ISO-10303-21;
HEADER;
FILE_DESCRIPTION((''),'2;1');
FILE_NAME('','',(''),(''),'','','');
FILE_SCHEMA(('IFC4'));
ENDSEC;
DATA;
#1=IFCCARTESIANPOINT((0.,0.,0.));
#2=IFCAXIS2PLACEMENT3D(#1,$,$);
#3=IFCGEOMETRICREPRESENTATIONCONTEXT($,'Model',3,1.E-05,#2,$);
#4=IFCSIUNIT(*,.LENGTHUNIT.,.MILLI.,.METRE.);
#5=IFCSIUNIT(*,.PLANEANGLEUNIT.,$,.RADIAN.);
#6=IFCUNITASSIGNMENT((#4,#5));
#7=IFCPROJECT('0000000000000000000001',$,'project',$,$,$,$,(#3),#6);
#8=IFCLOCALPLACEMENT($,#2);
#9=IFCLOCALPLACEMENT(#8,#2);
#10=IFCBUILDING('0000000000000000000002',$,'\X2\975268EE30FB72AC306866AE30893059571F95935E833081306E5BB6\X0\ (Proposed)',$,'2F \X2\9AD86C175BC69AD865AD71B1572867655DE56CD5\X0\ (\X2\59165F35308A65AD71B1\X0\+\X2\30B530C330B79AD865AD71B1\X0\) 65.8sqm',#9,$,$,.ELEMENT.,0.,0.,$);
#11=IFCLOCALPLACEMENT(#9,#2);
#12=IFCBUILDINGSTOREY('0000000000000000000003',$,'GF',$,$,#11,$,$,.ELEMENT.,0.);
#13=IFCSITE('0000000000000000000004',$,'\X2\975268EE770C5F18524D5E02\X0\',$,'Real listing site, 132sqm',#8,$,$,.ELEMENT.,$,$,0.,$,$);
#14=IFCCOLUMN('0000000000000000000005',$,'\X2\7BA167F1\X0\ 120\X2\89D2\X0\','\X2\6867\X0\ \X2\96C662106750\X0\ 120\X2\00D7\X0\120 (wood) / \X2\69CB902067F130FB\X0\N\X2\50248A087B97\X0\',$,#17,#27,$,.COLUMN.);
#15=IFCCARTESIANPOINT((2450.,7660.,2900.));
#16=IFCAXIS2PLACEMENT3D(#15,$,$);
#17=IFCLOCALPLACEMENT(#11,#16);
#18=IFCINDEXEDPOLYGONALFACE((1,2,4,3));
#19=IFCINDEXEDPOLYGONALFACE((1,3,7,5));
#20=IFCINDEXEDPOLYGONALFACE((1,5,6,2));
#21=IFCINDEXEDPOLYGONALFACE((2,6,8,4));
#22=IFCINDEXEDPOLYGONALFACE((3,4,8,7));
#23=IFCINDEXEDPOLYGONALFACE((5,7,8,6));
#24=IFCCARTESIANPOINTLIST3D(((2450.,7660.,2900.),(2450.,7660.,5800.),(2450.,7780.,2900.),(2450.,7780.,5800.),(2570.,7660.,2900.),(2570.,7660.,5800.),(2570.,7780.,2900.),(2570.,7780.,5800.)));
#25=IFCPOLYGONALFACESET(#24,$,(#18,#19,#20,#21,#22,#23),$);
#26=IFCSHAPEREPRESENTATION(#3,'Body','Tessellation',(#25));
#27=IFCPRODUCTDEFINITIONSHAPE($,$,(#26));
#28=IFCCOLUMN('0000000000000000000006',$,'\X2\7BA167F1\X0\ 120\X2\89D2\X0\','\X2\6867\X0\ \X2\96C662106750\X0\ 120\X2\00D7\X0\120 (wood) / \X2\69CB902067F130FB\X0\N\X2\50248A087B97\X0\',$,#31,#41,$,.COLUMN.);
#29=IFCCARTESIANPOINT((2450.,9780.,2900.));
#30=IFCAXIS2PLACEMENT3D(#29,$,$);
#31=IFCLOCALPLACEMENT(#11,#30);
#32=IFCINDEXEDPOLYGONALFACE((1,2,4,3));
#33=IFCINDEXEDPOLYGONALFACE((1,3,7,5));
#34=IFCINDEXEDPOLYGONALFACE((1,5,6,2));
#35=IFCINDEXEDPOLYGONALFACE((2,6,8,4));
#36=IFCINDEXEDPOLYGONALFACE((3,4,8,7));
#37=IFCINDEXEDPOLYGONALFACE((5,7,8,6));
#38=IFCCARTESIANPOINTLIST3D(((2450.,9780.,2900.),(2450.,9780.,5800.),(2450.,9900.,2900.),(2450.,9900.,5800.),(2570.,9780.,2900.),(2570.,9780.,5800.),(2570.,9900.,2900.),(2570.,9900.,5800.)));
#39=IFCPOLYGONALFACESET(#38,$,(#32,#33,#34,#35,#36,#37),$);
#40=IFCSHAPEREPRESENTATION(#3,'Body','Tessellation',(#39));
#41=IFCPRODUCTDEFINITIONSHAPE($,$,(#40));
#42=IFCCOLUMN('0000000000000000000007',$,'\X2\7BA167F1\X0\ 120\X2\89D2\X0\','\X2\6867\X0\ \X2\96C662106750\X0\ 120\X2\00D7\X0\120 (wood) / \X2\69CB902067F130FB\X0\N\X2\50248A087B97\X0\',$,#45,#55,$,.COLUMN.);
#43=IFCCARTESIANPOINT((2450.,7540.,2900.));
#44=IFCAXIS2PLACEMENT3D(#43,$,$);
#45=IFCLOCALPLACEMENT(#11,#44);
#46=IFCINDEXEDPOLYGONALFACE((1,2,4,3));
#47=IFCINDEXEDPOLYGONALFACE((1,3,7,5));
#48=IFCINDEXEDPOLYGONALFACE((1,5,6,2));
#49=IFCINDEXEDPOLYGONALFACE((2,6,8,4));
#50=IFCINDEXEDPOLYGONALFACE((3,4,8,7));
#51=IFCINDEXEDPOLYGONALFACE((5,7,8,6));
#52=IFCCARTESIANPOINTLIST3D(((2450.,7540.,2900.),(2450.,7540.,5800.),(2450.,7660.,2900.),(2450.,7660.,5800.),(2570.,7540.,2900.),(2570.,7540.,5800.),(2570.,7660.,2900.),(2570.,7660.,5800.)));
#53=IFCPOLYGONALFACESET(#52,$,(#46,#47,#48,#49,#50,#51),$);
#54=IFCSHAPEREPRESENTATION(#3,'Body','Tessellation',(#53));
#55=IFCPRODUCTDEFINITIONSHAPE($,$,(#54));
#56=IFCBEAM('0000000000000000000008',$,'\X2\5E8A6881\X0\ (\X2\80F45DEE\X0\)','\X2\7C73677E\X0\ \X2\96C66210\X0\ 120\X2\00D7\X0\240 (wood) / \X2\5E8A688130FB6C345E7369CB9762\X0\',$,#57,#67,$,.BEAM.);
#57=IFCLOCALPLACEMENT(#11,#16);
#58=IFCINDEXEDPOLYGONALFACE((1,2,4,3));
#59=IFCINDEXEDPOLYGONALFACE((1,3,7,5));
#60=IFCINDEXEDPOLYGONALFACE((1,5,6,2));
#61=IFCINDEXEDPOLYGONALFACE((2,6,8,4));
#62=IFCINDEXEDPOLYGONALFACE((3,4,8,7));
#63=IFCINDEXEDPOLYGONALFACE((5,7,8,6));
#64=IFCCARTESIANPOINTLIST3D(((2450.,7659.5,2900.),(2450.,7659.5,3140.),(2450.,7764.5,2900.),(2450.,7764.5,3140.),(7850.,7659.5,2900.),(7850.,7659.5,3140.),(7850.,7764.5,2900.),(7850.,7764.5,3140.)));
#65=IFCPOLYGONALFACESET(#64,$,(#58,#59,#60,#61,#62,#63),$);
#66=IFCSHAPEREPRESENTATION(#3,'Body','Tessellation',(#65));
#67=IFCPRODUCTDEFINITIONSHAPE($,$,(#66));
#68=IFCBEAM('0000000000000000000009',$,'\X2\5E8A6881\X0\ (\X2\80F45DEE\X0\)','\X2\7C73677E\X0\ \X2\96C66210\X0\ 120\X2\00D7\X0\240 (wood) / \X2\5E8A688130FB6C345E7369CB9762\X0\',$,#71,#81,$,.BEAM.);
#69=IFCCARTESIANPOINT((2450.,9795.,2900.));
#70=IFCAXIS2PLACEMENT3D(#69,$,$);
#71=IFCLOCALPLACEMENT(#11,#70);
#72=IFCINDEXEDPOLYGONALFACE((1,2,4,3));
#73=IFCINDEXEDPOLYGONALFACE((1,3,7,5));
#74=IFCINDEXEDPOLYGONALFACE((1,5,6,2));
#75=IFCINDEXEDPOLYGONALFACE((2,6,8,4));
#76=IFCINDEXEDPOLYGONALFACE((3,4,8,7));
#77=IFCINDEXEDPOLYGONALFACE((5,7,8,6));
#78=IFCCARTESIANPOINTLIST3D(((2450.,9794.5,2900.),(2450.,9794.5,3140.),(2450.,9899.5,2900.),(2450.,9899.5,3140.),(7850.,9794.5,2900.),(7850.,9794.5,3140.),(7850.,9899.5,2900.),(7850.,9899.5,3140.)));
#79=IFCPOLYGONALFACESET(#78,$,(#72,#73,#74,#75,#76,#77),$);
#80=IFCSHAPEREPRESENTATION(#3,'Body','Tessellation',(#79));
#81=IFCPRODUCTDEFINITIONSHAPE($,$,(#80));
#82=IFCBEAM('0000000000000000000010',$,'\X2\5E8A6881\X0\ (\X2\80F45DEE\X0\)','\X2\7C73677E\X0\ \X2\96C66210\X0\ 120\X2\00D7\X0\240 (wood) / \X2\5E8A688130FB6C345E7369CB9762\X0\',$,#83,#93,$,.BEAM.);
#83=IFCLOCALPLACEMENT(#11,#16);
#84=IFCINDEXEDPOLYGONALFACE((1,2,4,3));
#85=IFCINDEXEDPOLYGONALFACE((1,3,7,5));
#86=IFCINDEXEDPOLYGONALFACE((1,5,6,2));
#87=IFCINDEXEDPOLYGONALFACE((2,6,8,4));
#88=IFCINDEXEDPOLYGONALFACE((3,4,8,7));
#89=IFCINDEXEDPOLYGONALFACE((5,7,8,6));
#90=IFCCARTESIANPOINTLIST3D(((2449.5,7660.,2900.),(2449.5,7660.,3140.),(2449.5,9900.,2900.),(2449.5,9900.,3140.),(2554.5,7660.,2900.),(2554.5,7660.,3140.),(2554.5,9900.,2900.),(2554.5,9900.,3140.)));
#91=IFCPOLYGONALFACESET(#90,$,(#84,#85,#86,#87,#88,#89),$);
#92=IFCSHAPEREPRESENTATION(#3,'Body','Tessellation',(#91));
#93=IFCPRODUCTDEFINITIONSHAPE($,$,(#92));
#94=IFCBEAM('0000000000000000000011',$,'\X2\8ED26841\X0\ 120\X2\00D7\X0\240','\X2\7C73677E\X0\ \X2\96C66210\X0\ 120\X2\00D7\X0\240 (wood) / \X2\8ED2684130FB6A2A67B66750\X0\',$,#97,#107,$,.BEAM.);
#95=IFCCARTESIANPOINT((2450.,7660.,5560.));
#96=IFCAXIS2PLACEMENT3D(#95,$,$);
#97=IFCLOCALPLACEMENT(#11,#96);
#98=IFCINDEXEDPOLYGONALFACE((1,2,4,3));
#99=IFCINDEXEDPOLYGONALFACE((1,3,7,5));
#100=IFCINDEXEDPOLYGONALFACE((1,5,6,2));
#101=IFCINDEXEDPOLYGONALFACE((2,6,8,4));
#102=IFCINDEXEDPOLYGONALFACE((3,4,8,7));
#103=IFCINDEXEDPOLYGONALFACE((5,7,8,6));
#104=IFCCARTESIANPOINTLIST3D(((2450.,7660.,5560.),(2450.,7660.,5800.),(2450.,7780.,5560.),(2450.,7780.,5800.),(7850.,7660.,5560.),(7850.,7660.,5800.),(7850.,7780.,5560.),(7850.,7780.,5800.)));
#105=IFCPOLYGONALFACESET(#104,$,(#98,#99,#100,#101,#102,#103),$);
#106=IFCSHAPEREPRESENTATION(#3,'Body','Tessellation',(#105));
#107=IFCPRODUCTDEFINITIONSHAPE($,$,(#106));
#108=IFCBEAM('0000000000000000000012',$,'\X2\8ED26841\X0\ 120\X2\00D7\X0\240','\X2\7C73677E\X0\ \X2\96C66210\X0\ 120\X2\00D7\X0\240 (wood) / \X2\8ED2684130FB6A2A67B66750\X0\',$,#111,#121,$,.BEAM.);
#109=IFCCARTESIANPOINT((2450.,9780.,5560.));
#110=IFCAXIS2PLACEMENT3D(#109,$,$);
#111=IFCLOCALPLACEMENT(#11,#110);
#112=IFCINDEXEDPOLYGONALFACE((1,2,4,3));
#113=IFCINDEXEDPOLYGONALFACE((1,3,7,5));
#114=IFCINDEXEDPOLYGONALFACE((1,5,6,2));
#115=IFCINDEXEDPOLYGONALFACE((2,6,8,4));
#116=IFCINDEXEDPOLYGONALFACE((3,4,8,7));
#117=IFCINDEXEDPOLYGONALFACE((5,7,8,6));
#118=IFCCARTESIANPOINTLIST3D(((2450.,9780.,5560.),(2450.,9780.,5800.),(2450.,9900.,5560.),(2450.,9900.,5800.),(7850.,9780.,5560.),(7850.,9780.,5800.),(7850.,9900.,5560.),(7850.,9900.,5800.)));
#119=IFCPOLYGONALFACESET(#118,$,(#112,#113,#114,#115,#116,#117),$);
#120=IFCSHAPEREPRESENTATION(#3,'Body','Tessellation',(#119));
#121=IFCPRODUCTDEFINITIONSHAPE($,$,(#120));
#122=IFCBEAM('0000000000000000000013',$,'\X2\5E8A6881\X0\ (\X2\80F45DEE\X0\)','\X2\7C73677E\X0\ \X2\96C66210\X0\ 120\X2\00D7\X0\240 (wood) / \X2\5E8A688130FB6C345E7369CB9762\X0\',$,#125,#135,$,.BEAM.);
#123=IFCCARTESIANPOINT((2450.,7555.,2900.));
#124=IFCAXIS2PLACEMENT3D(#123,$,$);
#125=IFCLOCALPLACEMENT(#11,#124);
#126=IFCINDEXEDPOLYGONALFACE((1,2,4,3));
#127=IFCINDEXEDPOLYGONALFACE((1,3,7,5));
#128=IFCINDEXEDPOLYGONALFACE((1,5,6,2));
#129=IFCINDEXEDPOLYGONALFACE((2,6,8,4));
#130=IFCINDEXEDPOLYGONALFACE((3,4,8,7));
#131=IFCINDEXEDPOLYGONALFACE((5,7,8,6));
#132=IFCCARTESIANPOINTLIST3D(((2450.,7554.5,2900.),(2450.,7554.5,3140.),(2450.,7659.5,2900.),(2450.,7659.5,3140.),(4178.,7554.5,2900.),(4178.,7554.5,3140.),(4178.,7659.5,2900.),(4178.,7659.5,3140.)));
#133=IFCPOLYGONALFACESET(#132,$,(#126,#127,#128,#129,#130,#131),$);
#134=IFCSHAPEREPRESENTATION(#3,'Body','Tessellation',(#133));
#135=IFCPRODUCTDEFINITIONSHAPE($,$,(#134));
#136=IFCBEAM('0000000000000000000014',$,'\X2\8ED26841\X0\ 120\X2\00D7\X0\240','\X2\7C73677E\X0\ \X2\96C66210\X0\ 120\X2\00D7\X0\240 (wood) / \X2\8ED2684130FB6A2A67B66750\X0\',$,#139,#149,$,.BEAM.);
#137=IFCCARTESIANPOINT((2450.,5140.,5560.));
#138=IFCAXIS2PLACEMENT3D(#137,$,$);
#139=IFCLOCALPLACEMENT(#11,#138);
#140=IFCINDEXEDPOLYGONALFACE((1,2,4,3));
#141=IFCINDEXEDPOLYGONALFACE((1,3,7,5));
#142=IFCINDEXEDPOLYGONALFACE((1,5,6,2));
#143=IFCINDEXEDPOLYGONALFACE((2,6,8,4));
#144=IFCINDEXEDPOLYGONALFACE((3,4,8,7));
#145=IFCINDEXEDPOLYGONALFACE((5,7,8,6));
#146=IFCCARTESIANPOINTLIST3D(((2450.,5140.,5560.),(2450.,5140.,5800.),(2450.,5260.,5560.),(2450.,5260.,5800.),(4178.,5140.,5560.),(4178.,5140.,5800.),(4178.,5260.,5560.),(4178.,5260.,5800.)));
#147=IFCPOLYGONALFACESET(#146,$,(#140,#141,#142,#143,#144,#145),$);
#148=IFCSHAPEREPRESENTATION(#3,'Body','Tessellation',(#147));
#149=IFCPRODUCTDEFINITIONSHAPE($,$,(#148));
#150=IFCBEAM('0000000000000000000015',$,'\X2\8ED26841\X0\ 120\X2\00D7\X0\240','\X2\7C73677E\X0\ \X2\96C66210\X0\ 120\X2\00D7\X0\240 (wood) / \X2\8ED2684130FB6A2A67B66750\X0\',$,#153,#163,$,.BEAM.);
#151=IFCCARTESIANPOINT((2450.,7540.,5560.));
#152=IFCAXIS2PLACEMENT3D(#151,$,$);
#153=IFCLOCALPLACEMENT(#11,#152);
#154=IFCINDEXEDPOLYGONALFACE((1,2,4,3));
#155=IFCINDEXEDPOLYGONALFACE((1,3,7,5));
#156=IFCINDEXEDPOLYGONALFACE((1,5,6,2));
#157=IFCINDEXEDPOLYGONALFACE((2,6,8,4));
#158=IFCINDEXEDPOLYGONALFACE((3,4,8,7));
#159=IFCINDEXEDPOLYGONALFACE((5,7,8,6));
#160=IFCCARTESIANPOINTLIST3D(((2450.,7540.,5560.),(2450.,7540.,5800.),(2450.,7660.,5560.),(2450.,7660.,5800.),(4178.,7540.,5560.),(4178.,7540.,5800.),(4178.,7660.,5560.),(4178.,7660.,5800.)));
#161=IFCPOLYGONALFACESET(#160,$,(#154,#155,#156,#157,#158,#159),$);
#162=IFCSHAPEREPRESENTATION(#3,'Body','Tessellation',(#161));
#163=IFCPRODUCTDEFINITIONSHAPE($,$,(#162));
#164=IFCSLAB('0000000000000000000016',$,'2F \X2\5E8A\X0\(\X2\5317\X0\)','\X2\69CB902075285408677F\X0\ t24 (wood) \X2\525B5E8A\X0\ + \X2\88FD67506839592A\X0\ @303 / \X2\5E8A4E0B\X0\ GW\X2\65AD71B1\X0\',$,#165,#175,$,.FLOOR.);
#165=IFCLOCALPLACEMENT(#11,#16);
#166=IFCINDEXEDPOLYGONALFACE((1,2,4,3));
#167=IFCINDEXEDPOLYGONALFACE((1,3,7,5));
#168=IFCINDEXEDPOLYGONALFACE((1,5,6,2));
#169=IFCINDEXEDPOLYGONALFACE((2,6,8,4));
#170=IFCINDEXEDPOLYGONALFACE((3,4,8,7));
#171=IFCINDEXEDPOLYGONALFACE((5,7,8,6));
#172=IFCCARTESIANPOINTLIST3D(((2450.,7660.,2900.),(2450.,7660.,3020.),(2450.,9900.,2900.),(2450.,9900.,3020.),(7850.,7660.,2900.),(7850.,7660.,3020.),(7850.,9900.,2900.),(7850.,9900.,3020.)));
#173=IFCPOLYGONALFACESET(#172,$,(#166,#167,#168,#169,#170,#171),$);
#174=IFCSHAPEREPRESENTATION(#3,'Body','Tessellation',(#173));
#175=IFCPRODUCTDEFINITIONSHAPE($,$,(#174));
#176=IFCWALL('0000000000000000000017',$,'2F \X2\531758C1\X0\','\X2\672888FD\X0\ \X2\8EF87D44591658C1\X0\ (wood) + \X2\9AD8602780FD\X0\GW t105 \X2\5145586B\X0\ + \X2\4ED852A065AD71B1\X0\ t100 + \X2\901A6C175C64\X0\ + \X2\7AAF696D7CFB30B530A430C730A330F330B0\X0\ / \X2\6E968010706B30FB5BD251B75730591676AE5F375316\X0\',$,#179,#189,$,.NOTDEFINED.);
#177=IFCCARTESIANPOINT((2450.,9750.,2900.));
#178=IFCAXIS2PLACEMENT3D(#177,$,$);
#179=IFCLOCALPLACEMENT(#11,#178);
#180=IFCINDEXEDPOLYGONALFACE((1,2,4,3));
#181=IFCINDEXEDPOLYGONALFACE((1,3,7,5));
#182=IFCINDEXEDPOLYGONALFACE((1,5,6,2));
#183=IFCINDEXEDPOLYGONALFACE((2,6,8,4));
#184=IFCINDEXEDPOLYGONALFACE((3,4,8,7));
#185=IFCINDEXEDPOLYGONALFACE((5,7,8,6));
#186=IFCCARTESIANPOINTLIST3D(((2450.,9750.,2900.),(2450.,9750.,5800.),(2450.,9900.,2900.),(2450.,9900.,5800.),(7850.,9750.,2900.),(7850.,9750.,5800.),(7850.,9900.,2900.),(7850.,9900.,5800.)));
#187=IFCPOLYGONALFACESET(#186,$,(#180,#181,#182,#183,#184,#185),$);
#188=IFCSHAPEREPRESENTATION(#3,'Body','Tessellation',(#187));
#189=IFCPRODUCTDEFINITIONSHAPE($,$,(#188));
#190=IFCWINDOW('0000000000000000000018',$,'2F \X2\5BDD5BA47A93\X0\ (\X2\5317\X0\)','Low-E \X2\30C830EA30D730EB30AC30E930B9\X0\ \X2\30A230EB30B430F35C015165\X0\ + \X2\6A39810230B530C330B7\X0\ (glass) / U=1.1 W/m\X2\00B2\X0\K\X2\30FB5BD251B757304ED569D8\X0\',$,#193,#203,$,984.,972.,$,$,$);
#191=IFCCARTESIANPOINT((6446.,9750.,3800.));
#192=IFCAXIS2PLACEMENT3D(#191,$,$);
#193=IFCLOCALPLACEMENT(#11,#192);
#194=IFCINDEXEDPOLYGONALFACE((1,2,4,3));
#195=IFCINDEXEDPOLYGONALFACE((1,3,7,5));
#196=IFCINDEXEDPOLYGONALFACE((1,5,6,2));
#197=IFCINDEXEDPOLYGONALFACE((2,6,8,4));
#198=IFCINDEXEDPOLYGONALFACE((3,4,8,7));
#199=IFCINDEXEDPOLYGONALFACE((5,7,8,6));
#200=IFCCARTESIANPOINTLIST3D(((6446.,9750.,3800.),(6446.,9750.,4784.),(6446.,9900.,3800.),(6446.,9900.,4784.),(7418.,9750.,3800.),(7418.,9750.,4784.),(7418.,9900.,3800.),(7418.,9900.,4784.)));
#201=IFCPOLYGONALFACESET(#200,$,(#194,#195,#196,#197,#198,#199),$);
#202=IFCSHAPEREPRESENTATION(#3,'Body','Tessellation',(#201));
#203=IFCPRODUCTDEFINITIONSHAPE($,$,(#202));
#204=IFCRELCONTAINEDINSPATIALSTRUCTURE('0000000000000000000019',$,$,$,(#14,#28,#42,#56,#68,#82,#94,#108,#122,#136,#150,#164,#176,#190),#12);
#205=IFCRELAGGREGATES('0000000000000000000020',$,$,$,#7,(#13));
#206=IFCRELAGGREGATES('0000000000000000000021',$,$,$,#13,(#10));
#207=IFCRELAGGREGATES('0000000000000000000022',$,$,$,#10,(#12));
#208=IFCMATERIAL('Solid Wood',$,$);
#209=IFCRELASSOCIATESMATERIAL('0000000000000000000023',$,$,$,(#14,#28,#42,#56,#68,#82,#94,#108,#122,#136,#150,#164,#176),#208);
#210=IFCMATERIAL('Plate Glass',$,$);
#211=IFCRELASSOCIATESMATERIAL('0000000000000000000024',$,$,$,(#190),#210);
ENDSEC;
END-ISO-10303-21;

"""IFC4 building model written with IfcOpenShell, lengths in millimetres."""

from ifc_helpers import new_model, si_unit, frame, frame_2d, origin, place, context, project, spatial, rectangle, extrude, material, element, fill, save


model = new_model("IFC4")

# Units and contexts
model_context = context("Model", 3, precision=1e-05, world=origin())
ifc_project = project(units=[si_unit("LENGTHUNIT", "METRE", prefix="MILLI"), si_unit("PLANEANGLEUNIT", "RADIAN")], contexts=[model_context])

# Site, building, storey
site_placement = place(None, origin())
site = spatial("IfcSite", under=ifc_project, at=site_placement, Name="青森県弘前市", ObjectType="Real listing site, 132sqm", CompositionType="ELEMENT", RefElevation=0.0)
building_placement = place(site_placement, origin())
building = spatial("IfcBuilding", under=site, at=building_placement, Name="青森・犬と暮らす土間広めの家 (Proposed)", ObjectType="2F 高気密高断熱在来工法 (外張り断熱+サッシ高断熱) 65.8sqm", CompositionType="ELEMENT", ElevationOfRefHeight=0.0, ElevationOfTerrain=0.0)
storey_placement = place(building_placement, origin())
storey = spatial("IfcBuildingStorey", under=building, at=storey_placement, Name="GF", CompositionType="ELEMENT", Elevation=0.0)

# Columns
ifc_material_1 = material(Name="Solid Wood")
column_1_placement = place(storey_placement, frame((2450.0, 7660.0, 2900.0)))
element("IfcColumn", 1, at=column_1_placement, inside=storey, material=ifc_material_1, Name="管柱 120角", Description="桧 集成材 120×120 (wood) / 構造柱・N値計算", PredefinedType="COLUMN", context=model_context, shape_type="SweptSolid", body=[
    extrude(rectangle(XDim=120.0, YDim=120.0, at=frame_2d((60.0, 60.0))), frame((2450.0, 7660.0, 2900.0)), (0.0, 0.0, 1.0), 2900.0),
])
column_2_placement = place(storey_placement, frame((2450.0, 9780.0, 2900.0)))
element("IfcColumn", 2, at=column_2_placement, inside=storey, material=ifc_material_1, Name="管柱 120角", Description="桧 集成材 120×120 (wood) / 構造柱・N値計算", PredefinedType="COLUMN", context=model_context, shape_type="SweptSolid", body=[
    extrude(rectangle(XDim=120.0, YDim=120.0, at=frame_2d((60.0, 60.0))), frame((2450.0, 9780.0, 2900.0)), (0.0, 0.0, 1.0), 2900.0),
])
column_3_placement = place(storey_placement, frame((2450.0, 7540.0, 2900.0)))
element("IfcColumn", 3, at=column_3_placement, inside=storey, material=ifc_material_1, Name="管柱 120角", Description="桧 集成材 120×120 (wood) / 構造柱・N値計算", PredefinedType="COLUMN", context=model_context, shape_type="SweptSolid", body=[
    extrude(rectangle(XDim=120.0, YDim=120.0, at=frame_2d((60.0, 60.0))), frame((2450.0, 7540.0, 2900.0)), (0.0, 0.0, 1.0), 2900.0),
])

# Beams
beam_1_placement = place(storey_placement, frame((2450.0, 7660.0, 2900.0)))
element("IfcBeam", 4, at=beam_1_placement, inside=storey, material=ifc_material_1, Name="床梁 (胴差)", Description="米松 集成 120×240 (wood) / 床梁・水平構面", PredefinedType="BEAM", context=model_context, shape_type="SweptSolid", body=[
    extrude(rectangle(XDim=5400.0, YDim=105.0, at=frame_2d((2700.0, 52.0))), frame((2450.0, 7660.0, 2900.0)), (0.0, 0.0, 1.0), 240.0),
])
beam_2_placement = place(storey_placement, frame((2450.0, 9795.0, 2900.0)))
element("IfcBeam", 5, at=beam_2_placement, inside=storey, material=ifc_material_1, Name="床梁 (胴差)", Description="米松 集成 120×240 (wood) / 床梁・水平構面", PredefinedType="BEAM", context=model_context, shape_type="SweptSolid", body=[
    extrude(rectangle(XDim=5400.0, YDim=105.0, at=frame_2d((2700.0, 52.0))), frame((2450.0, 9795.0, 2900.0)), (0.0, 0.0, 1.0), 240.0),
])
beam_3_placement = place(storey_placement, frame((2450.0, 7660.0, 2900.0)))
element("IfcBeam", 6, at=beam_3_placement, inside=storey, material=ifc_material_1, Name="床梁 (胴差)", Description="米松 集成 120×240 (wood) / 床梁・水平構面", PredefinedType="BEAM", context=model_context, shape_type="SweptSolid", body=[
    extrude(rectangle(XDim=105.0, YDim=2240.0, at=frame_2d((52.0, 1120.0))), frame((2450.0, 7660.0, 2900.0)), (0.0, 0.0, 1.0), 240.0),
])
beam_4_placement = place(storey_placement, frame((2450.0, 7660.0, 5560.0)))
element("IfcBeam", 7, at=beam_4_placement, inside=storey, material=ifc_material_1, Name="軒桁 120×240", Description="米松 集成 120×240 (wood) / 軒桁・横架材", PredefinedType="BEAM", context=model_context, shape_type="SweptSolid", body=[
    extrude(rectangle(XDim=5400.0, YDim=120.0, at=frame_2d((2700.0, 60.0))), frame((2450.0, 7660.0, 5560.0)), (0.0, 0.0, 1.0), 240.0),
])
beam_5_placement = place(storey_placement, frame((2450.0, 9780.0, 5560.0)))
element("IfcBeam", 8, at=beam_5_placement, inside=storey, material=ifc_material_1, Name="軒桁 120×240", Description="米松 集成 120×240 (wood) / 軒桁・横架材", PredefinedType="BEAM", context=model_context, shape_type="SweptSolid", body=[
    extrude(rectangle(XDim=5400.0, YDim=120.0, at=frame_2d((2700.0, 60.0))), frame((2450.0, 9780.0, 5560.0)), (0.0, 0.0, 1.0), 240.0),
])
beam_6_placement = place(storey_placement, frame((2450.0, 7555.0, 2900.0)))
element("IfcBeam", 9, at=beam_6_placement, inside=storey, material=ifc_material_1, Name="床梁 (胴差)", Description="米松 集成 120×240 (wood) / 床梁・水平構面", PredefinedType="BEAM", context=model_context, shape_type="SweptSolid", body=[
    extrude(rectangle(XDim=1728.0, YDim=105.0, at=frame_2d((864.0, 52.0))), frame((2450.0, 7555.0, 2900.0)), (0.0, 0.0, 1.0), 240.0),
])
beam_7_placement = place(storey_placement, frame((2450.0, 5140.0, 5560.0)))
element("IfcBeam", 10, at=beam_7_placement, inside=storey, material=ifc_material_1, Name="軒桁 120×240", Description="米松 集成 120×240 (wood) / 軒桁・横架材", PredefinedType="BEAM", context=model_context, shape_type="SweptSolid", body=[
    extrude(rectangle(XDim=1728.0, YDim=120.0, at=frame_2d((864.0, 60.0))), frame((2450.0, 5140.0, 5560.0)), (0.0, 0.0, 1.0), 240.0),
])
beam_8_placement = place(storey_placement, frame((2450.0, 7540.0, 5560.0)))
element("IfcBeam", 11, at=beam_8_placement, inside=storey, material=ifc_material_1, Name="軒桁 120×240", Description="米松 集成 120×240 (wood) / 軒桁・横架材", PredefinedType="BEAM", context=model_context, shape_type="SweptSolid", body=[
    extrude(rectangle(XDim=1728.0, YDim=120.0, at=frame_2d((864.0, 60.0))), frame((2450.0, 7540.0, 5560.0)), (0.0, 0.0, 1.0), 240.0),
])

# Slab
slab_placement = place(storey_placement, frame((2450.0, 7660.0, 2900.0)))
element("IfcSlab", 12, at=slab_placement, inside=storey, material=ifc_material_1, Name="2F 床(北)", Description="構造用合板 t24 (wood) 剛床 + 製材根太 @303 / 床下 GW断熱", PredefinedType="FLOOR", context=model_context, shape_type="SweptSolid", body=[
    extrude(rectangle(XDim=5400.0, YDim=2240.0, at=frame_2d((2700.0, 1120.0))), frame((2450.0, 7660.0, 2900.0)), (0.0, 0.0, 1.0), 120.0),
])

# Wall, opening, window
wall_placement = place(storey_placement, frame((2450.0, 9750.0, 2900.0)))
wall = element("IfcWall", 13, at=wall_placement, inside=storey, material=ifc_material_1, Name="2F 北壁", Description="木製 軸組外壁 (wood) + 高性能GW t105 充填 + 付加断熱 t100 + 通気層 + 窯業系サイディング / 準耐火・寒冷地外皮強化", PredefinedType="NOTDEFINED", context=model_context, shape_type="SweptSolid", body=[
    extrude(rectangle(XDim=5400.0, YDim=150.0, at=frame_2d((2700.0, 75.0))), frame((2450.0, 9750.0, 2900.0)), (0.0, 0.0, 1.0), 2900.0),
])
opening_placement = place(storey_placement, frame((6446.0, 9750.0, 3800.0)))
opening = element("IfcOpeningElement", 14, at=opening_placement, cuts=wall, PredefinedType="NOTDEFINED", context=model_context, shape_type="SweptSolid", body=[
    extrude(rectangle(XDim=972.0, YDim=150.0, at=frame_2d((486.0, 75.0))), frame((6446.0, 9750.0, 3800.0)), (0.0, 0.0, 1.0), 984.0),
])
ifc_material_2 = material(Name="Plate Glass")
window_placement = place(storey_placement, frame((6446.0, 9750.0, 3800.0)))
window = element("IfcWindow", 15, at=window_placement, inside=storey, material=ifc_material_2, Name="2F 寝室窓 (北)", Description="Low-E トリプルガラス アルゴン封入 + 樹脂サッシ (glass) / U=1.1 W/m²K・寒冷地仕様", OverallHeight=984.0, OverallWidth=972.0, context=model_context, shape_type="SweptSolid", body=[
    extrude(rectangle(XDim=972.0, YDim=150.0, at=frame_2d((486.0, 75.0))), frame((6446.0, 9750.0, 3800.0)), (0.0, 0.0, 1.0), 984.0),
])
fill(opening, window)

save(model, "model.ifc")
